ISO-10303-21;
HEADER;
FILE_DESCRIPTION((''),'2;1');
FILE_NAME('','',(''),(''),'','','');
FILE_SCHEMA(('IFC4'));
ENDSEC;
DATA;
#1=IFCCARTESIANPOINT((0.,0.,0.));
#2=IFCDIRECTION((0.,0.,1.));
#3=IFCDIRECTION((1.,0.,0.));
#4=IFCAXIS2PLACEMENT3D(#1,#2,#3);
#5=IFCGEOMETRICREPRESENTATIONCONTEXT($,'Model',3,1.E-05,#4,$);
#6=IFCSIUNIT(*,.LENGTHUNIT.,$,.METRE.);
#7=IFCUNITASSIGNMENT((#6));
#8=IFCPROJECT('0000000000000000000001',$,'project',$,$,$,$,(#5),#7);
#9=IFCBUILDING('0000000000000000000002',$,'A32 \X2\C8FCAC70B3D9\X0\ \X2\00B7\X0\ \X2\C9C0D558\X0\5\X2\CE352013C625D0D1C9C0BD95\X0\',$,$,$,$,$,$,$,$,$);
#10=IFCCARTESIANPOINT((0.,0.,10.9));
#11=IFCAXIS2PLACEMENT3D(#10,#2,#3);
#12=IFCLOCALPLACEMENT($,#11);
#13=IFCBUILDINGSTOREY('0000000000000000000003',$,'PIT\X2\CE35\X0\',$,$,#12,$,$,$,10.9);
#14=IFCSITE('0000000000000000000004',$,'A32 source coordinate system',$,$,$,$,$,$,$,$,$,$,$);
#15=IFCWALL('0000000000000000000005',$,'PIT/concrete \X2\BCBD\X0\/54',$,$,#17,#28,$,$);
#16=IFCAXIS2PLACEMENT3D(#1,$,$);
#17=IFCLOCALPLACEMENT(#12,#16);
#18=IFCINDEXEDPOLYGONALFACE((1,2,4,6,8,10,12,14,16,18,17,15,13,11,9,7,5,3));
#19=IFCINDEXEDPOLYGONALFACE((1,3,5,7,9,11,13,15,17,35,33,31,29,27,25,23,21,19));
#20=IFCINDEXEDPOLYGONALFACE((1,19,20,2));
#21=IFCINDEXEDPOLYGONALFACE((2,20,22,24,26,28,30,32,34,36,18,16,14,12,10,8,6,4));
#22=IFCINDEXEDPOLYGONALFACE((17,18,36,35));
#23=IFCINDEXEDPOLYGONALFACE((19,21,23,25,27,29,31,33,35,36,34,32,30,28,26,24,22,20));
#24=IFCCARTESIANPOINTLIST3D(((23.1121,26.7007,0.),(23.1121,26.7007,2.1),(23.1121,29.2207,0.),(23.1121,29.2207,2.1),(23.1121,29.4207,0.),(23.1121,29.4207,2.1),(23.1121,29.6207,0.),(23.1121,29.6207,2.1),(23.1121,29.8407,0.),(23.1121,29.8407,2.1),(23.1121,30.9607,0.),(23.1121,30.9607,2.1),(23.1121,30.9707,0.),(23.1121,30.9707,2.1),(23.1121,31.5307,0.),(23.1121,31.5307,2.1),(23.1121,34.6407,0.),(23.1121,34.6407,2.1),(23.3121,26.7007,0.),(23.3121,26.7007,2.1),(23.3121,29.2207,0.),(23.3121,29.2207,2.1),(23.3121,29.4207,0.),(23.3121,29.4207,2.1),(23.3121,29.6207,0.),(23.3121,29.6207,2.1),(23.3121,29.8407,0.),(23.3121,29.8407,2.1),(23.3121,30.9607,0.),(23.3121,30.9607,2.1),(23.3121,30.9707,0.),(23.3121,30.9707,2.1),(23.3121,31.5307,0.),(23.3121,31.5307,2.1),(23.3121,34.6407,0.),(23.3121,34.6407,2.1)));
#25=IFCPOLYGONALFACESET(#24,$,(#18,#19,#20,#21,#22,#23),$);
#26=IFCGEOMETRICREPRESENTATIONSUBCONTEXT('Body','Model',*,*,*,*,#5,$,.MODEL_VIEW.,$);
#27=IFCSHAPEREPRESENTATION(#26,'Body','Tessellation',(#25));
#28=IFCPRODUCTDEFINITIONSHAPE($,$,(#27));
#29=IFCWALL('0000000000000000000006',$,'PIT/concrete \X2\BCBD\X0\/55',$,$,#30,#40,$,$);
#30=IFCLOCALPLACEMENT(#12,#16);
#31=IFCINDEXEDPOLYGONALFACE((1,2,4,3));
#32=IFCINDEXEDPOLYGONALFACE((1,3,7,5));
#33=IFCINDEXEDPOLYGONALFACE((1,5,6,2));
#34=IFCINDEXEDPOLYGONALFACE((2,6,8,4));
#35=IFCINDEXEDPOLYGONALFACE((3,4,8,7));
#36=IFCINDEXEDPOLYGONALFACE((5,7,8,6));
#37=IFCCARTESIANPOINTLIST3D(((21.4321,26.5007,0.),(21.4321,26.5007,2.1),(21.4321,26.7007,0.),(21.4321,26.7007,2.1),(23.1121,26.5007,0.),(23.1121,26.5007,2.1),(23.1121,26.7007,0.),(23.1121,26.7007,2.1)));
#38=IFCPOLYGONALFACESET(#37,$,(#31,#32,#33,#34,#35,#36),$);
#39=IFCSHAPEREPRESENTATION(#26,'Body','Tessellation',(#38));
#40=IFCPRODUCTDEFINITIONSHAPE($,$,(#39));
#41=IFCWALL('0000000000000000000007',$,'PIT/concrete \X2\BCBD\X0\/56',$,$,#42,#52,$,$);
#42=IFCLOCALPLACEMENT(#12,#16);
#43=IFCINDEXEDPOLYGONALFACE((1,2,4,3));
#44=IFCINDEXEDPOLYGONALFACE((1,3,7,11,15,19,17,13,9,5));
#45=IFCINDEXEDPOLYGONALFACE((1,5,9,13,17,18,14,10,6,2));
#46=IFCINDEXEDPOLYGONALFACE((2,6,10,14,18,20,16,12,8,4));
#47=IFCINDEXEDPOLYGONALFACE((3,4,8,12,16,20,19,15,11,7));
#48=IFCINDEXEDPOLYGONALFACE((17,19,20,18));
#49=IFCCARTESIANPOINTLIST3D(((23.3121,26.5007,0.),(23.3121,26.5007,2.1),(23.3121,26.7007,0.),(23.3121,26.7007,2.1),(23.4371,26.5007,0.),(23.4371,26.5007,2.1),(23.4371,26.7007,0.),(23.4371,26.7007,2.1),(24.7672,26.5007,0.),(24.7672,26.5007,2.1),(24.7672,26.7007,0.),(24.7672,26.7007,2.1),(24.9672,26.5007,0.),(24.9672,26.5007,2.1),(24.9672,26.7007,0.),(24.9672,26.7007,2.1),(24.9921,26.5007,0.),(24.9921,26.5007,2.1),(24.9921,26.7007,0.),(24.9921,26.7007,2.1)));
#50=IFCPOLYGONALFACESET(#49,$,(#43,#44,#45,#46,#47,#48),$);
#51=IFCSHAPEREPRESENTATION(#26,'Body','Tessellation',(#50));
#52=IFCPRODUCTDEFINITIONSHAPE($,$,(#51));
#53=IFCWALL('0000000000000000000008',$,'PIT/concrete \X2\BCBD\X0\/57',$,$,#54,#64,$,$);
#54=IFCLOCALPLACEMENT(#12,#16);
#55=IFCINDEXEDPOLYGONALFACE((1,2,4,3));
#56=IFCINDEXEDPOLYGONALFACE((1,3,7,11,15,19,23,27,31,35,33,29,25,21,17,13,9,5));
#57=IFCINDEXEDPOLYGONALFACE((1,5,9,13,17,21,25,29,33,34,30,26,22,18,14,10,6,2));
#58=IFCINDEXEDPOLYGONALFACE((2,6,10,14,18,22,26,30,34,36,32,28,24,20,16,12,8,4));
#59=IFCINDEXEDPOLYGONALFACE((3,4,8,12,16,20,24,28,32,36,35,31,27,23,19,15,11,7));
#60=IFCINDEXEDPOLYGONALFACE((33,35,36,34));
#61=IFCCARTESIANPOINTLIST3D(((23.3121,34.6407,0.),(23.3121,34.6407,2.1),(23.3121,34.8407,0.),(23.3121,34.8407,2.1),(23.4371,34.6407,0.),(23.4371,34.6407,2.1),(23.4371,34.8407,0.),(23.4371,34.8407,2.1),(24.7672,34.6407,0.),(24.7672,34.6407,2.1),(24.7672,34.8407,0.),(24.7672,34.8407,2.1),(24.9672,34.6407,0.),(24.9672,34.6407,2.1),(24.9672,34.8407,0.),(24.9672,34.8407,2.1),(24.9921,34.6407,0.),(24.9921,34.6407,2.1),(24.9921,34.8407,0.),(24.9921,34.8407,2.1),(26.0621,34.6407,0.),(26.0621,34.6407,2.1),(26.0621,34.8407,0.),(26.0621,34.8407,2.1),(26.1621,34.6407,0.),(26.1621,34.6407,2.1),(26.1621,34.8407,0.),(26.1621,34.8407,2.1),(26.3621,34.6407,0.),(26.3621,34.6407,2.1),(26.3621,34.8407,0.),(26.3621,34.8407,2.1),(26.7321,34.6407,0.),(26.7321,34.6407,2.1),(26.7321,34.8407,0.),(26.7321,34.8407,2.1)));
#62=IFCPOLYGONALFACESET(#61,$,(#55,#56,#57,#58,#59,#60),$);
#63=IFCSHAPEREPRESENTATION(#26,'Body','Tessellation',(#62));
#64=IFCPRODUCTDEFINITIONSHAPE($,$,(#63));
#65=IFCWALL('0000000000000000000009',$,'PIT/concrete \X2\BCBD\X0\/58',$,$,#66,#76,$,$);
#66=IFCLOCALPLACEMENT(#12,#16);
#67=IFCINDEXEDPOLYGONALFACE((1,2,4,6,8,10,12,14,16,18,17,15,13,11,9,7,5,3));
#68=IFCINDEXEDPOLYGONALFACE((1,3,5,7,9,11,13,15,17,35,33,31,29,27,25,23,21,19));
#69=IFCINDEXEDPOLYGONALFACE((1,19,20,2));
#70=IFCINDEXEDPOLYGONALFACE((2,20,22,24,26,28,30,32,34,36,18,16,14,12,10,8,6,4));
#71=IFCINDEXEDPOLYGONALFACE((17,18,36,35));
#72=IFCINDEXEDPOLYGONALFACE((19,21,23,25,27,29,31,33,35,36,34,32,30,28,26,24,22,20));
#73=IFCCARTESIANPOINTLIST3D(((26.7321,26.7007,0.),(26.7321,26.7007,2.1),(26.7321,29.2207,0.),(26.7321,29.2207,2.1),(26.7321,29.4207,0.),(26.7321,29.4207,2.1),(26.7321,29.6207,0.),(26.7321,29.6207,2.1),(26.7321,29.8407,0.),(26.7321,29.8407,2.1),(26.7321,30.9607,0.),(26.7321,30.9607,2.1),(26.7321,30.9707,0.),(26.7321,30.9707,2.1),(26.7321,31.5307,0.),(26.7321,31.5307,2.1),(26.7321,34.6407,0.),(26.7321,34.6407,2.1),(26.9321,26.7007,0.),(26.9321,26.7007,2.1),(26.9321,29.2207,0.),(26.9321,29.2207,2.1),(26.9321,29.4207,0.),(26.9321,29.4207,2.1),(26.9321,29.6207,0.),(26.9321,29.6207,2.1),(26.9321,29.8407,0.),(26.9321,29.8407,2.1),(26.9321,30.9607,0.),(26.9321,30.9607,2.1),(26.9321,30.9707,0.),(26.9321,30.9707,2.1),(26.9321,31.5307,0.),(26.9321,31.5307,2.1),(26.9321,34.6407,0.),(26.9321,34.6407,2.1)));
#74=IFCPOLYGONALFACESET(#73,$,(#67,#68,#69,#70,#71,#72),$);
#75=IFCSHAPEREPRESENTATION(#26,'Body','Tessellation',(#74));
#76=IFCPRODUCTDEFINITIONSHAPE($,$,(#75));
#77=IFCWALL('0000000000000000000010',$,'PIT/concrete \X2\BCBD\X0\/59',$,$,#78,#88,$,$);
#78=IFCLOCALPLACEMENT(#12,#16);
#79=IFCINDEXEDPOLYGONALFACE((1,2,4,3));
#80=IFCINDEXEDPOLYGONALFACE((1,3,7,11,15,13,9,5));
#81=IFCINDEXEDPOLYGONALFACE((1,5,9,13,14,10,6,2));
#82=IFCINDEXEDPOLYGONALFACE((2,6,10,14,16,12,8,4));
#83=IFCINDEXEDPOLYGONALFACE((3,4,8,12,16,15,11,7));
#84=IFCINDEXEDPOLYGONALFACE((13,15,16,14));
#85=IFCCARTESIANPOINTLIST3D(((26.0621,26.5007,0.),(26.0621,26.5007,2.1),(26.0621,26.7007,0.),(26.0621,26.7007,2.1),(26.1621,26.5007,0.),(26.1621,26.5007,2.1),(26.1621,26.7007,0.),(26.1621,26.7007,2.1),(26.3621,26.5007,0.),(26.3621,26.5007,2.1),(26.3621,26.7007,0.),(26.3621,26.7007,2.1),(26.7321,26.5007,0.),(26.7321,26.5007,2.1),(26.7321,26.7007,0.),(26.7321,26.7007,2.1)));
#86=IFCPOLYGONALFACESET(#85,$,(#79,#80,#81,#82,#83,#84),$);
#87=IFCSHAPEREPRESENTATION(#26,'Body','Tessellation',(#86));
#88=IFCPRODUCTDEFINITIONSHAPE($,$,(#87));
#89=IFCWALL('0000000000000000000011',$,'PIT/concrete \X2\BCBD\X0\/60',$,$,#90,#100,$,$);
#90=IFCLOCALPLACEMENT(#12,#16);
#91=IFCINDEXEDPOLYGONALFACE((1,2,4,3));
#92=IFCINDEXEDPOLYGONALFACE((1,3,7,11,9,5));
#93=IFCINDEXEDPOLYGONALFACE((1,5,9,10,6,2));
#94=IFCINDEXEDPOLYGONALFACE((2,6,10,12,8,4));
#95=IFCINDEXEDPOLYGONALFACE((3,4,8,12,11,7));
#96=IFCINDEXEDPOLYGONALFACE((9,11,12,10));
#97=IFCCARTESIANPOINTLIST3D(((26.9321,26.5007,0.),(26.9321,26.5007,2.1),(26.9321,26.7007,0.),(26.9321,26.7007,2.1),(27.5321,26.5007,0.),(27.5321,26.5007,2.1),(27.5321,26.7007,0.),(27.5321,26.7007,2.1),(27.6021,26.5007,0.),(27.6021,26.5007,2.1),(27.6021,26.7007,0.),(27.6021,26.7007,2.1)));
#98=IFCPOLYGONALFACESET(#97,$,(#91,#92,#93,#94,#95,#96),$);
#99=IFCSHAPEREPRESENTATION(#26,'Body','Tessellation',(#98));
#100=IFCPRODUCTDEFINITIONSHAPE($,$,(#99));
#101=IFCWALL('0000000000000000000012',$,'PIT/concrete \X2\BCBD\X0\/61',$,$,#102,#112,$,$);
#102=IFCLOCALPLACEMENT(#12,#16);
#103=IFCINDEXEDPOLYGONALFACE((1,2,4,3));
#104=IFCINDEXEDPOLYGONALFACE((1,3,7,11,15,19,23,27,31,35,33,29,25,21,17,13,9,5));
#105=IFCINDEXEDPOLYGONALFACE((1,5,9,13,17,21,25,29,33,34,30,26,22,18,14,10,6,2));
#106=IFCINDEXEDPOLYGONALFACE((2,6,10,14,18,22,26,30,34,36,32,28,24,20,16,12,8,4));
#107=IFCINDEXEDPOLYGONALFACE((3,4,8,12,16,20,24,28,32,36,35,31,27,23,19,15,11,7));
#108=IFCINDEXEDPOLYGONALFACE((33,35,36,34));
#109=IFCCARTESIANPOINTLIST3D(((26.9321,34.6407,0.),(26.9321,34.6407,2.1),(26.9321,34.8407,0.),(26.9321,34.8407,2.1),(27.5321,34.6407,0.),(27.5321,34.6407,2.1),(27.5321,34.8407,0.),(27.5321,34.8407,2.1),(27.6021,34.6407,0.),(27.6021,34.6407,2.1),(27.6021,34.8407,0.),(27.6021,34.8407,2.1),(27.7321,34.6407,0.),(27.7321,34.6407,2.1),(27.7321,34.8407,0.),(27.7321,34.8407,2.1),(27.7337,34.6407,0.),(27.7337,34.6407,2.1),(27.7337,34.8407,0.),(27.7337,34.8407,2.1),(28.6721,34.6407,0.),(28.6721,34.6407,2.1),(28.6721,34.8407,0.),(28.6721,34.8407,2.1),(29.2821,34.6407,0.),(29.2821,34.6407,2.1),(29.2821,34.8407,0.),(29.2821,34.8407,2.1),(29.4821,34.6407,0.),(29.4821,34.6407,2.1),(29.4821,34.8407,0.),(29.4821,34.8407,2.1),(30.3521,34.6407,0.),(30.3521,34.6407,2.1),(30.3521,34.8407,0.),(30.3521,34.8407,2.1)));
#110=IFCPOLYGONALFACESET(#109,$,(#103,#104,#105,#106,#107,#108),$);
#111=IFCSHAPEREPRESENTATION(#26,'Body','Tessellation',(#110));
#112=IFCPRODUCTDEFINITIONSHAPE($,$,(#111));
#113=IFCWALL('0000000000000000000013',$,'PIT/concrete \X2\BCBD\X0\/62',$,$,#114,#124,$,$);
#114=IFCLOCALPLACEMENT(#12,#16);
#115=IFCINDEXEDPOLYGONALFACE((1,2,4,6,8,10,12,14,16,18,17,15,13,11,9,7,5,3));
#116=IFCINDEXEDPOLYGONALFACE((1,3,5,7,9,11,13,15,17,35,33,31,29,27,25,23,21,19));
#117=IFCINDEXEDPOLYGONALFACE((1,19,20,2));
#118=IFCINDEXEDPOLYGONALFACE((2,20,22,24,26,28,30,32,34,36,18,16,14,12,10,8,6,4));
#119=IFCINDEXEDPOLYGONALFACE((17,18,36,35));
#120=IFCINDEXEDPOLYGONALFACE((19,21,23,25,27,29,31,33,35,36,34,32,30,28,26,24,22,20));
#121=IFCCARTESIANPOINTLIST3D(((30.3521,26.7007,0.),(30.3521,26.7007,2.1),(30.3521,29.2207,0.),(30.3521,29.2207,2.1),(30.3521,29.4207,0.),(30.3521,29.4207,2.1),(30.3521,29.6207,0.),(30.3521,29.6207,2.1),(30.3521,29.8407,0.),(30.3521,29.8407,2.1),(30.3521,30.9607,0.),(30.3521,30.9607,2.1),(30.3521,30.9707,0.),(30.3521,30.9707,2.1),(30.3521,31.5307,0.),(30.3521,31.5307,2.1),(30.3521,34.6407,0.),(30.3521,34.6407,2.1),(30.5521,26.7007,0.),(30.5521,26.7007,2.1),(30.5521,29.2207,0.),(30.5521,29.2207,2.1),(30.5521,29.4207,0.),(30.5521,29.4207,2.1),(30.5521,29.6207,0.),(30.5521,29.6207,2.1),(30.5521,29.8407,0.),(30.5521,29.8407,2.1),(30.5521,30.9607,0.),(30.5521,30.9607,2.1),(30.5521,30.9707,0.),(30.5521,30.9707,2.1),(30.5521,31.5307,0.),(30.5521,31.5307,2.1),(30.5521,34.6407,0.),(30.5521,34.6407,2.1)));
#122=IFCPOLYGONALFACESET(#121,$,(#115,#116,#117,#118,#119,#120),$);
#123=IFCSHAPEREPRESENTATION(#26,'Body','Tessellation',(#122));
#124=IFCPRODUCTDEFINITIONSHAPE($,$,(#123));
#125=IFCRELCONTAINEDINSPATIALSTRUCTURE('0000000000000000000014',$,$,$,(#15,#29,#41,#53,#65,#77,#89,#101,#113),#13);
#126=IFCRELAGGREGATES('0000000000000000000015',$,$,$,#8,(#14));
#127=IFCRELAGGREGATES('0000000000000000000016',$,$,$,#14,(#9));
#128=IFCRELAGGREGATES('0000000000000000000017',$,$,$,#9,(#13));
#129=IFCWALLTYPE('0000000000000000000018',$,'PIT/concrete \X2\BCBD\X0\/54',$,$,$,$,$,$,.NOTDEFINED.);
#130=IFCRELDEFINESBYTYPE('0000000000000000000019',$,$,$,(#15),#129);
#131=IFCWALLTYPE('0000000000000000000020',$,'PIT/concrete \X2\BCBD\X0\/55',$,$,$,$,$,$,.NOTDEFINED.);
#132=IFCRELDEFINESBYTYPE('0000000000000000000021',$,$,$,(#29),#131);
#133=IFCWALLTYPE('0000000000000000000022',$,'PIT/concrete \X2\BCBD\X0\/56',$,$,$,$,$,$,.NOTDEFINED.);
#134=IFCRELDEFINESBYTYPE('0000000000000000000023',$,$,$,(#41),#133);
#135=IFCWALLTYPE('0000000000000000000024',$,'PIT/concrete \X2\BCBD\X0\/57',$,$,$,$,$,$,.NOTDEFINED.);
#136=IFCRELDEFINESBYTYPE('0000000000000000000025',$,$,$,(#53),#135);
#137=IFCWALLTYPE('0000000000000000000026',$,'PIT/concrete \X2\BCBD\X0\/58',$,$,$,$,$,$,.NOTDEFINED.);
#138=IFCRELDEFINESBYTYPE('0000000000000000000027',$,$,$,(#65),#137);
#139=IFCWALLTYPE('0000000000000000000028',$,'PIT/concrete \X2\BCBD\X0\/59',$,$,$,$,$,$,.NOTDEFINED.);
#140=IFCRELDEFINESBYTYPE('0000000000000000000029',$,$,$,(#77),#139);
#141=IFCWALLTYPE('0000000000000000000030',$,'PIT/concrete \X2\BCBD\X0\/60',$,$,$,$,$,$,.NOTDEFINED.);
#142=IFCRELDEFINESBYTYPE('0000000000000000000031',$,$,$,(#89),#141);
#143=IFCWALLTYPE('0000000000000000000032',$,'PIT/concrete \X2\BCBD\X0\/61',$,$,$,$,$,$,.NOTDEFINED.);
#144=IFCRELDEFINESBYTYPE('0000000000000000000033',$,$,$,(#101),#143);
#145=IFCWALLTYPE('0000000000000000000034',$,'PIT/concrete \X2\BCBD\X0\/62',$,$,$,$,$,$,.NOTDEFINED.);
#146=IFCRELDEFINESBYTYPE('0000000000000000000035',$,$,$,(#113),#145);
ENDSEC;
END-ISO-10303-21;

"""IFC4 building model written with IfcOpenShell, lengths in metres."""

from ifc_helpers import new_model, si_unit, frame, origin, origin_with_axes, place, context, subcontext, project, spatial, polyline, outline, extrude, source, transform, mapped, type_object, type_shapes, element, save


model = new_model("IFC4")

# Units and contexts
model_context = context("Model", 3, precision=1e-05, world=origin_with_axes())
body_context = subcontext(model_context, "Body", "Model", "MODEL_VIEW")
ifc_project = project(units=[si_unit("LENGTHUNIT", "METRE")], contexts=[model_context])

# Site, building, storey
site = spatial("IfcSite", under=ifc_project, Name="A32 source coordinate system")
building = spatial("IfcBuilding", under=site, Name="A32 주거동 · 지하5층–옥탑지붕")
storey_placement = place(None, frame((0.0, 0.0, 10.9), z_axis=(0.0, 0.0, 1.0), x_axis=(1.0, 0.0, 0.0)))
storey = spatial("IfcBuildingStorey", under=building, at=storey_placement, Name="PIT층", Elevation=10.9)

# Walls
wall_type_1 = type_object("IfcWallType", Name="PIT/concrete 벽/54", PredefinedType="NOTDEFINED")
shared_shape_1 = source(origin(), body_context, "Body", "SweptSolid", [
    extrude(outline(polyline([(23.3121, 30.9707), (23.3121, 30.9607), (23.3121, 29.8407), (23.3121, 29.6207), (23.3121, 29.4207), (23.3121, 29.2207), (23.3121, 26.7007), (23.1121, 26.7007), (23.1121, 29.2207), (23.1121, 29.4207), (23.1121, 29.6207), (23.1121, 29.8407), (23.1121, 30.9607), (23.1121, 30.9707), (23.1121, 31.5307), (23.1121, 34.6407), (23.3121, 34.6407), (23.3121, 31.5307), (23.3121, 30.9707)])), origin(), (0.0, 0.0, 1.0), 2.1),
])
type_shapes(wall_type_1, [shared_shape_1])
wall_1_placement = place(storey_placement, origin_with_axes())
element("IfcWall", 1, at=wall_1_placement, inside=storey, type_object=wall_type_1, Name="PIT/concrete 벽/54", context=body_context, shape_type="MappedRepresentation", body=[
    mapped(shared_shape_1, transform((0.0, 0.0, 0.0), scale=1.0)),
])
wall_type_2 = type_object("IfcWallType", Name="PIT/concrete 벽/55", PredefinedType="NOTDEFINED")
shared_shape_2 = source(origin(), body_context, "Body", "SweptSolid", [
    extrude(outline(polyline([(21.4321, 26.7007), (23.1121, 26.7007), (23.1121, 26.5007), (21.4321, 26.5007), (21.4321, 26.7007)])), origin(), (0.0, 0.0, 1.0), 2.1),
])
type_shapes(wall_type_2, [shared_shape_2])
wall_2_placement = place(storey_placement, origin_with_axes())
element("IfcWall", 2, at=wall_2_placement, inside=storey, type_object=wall_type_2, Name="PIT/concrete 벽/55", context=body_context, shape_type="MappedRepresentation", body=[
    mapped(shared_shape_2, transform((0.0, 0.0, 0.0), scale=1.0)),
])
wall_type_3 = type_object("IfcWallType", Name="PIT/concrete 벽/56", PredefinedType="NOTDEFINED")
shared_shape_3 = source(origin(), body_context, "Body", "SweptSolid", [
    extrude(outline(polyline([(24.9672, 26.7007), (24.9921, 26.7007), (24.9921, 26.5007), (24.9672, 26.5007), (24.7672, 26.5007), (23.4371, 26.5007), (23.3121, 26.5007), (23.3121, 26.7007), (23.4371, 26.7007), (24.7672, 26.7007), (24.9672, 26.7007)])), origin(), (0.0, 0.0, 1.0), 2.1),
])
type_shapes(wall_type_3, [shared_shape_3])
wall_3_placement = place(storey_placement, origin_with_axes())
element("IfcWall", 3, at=wall_3_placement, inside=storey, type_object=wall_type_3, Name="PIT/concrete 벽/56", context=body_context, shape_type="MappedRepresentation", body=[
    mapped(shared_shape_3, transform((0.0, 0.0, 0.0), scale=1.0)),
])
wall_type_4 = type_object("IfcWallType", Name="PIT/concrete 벽/57", PredefinedType="NOTDEFINED")
shared_shape_4 = source(origin(), body_context, "Body", "SweptSolid", [
    extrude(outline(polyline([(24.7672, 34.8407), (24.9672, 34.8407), (24.9921, 34.8407), (26.0621, 34.8407), (26.1621, 34.8407), (26.3621, 34.8407), (26.7321, 34.8407), (26.7321, 34.6407), (26.3621, 34.6407), (26.1621, 34.6407), (26.0621, 34.6407), (24.9921, 34.6407), (24.9672, 34.6407), (24.7672, 34.6407), (23.4371, 34.6407), (23.3121, 34.6407), (23.3121, 34.8407), (23.4371, 34.8407), (24.7672, 34.8407)])), origin(), (0.0, 0.0, 1.0), 2.1),
])
type_shapes(wall_type_4, [shared_shape_4])
wall_4_placement = place(storey_placement, origin_with_axes())
element("IfcWall", 4, at=wall_4_placement, inside=storey, type_object=wall_type_4, Name="PIT/concrete 벽/57", context=body_context, shape_type="MappedRepresentation", body=[
    mapped(shared_shape_4, transform((0.0, 0.0, 0.0), scale=1.0)),
])
wall_type_5 = type_object("IfcWallType", Name="PIT/concrete 벽/58", PredefinedType="NOTDEFINED")
shared_shape_5 = source(origin(), body_context, "Body", "SweptSolid", [
    extrude(outline(polyline([(26.9321, 30.9707), (26.9321, 30.9607), (26.9321, 29.8407), (26.9321, 29.6207), (26.9321, 29.4207), (26.9321, 29.2207), (26.9321, 26.7007), (26.7321, 26.7007), (26.7321, 29.2207), (26.7321, 29.4207), (26.7321, 29.6207), (26.7321, 29.8407), (26.7321, 30.9607), (26.7321, 30.9707), (26.7321, 31.5307), (26.7321, 34.6407), (26.9321, 34.6407), (26.9321, 31.5307), (26.9321, 30.9707)])), origin(), (0.0, 0.0, 1.0), 2.1),
])
type_shapes(wall_type_5, [shared_shape_5])
wall_5_placement = place(storey_placement, origin_with_axes())
element("IfcWall", 5, at=wall_5_placement, inside=storey, type_object=wall_type_5, Name="PIT/concrete 벽/58", context=body_context, shape_type="MappedRepresentation", body=[
    mapped(shared_shape_5, transform((0.0, 0.0, 0.0), scale=1.0)),
])
wall_type_6 = type_object("IfcWallType", Name="PIT/concrete 벽/59", PredefinedType="NOTDEFINED")
shared_shape_6 = source(origin(), body_context, "Body", "SweptSolid", [
    extrude(outline(polyline([(26.1621, 26.5007), (26.0621, 26.5007), (26.0621, 26.7007), (26.1621, 26.7007), (26.3621, 26.7007), (26.7321, 26.7007), (26.7321, 26.5007), (26.3621, 26.5007), (26.1621, 26.5007)])), origin(), (0.0, 0.0, 1.0), 2.1),
])
type_shapes(wall_type_6, [shared_shape_6])
wall_6_placement = place(storey_placement, origin_with_axes())
element("IfcWall", 6, at=wall_6_placement, inside=storey, type_object=wall_type_6, Name="PIT/concrete 벽/59", context=body_context, shape_type="MappedRepresentation", body=[
    mapped(shared_shape_6, transform((0.0, 0.0, 0.0), scale=1.0)),
])
wall_type_7 = type_object("IfcWallType", Name="PIT/concrete 벽/60", PredefinedType="NOTDEFINED")
shared_shape_7 = source(origin(), body_context, "Body", "SweptSolid", [
    extrude(outline(polyline([(27.6021, 26.5007), (27.5321, 26.5007), (26.9321, 26.5007), (26.9321, 26.7007), (27.5321, 26.7007), (27.6021, 26.7007), (27.6021, 26.5007)])), origin(), (0.0, 0.0, 1.0), 2.1),
])
type_shapes(wall_type_7, [shared_shape_7])
wall_7_placement = place(storey_placement, origin_with_axes())
element("IfcWall", 7, at=wall_7_placement, inside=storey, type_object=wall_type_7, Name="PIT/concrete 벽/60", context=body_context, shape_type="MappedRepresentation", body=[
    mapped(shared_shape_7, transform((0.0, 0.0, 0.0), scale=1.0)),
])
wall_type_8 = type_object("IfcWallType", Name="PIT/concrete 벽/61", PredefinedType="NOTDEFINED")
shared_shape_8 = source(origin(), body_context, "Body", "SweptSolid", [
    extrude(outline(polyline([(27.6021, 34.8407), (27.7321, 34.8407), (27.7337, 34.8407), (28.6721, 34.8407), (29.2821, 34.8407), (29.4821, 34.8407), (30.3521, 34.8407), (30.3521, 34.6407), (29.4821, 34.6407), (29.2821, 34.6407), (28.6721, 34.6407), (27.7337, 34.6407), (27.7321, 34.6407), (27.6021, 34.6407), (27.5321, 34.6407), (26.9321, 34.6407), (26.9321, 34.8407), (27.5321, 34.8407), (27.6021, 34.8407)])), origin(), (0.0, 0.0, 1.0), 2.1),
])
type_shapes(wall_type_8, [shared_shape_8])
wall_8_placement = place(storey_placement, origin_with_axes())
element("IfcWall", 8, at=wall_8_placement, inside=storey, type_object=wall_type_8, Name="PIT/concrete 벽/61", context=body_context, shape_type="MappedRepresentation", body=[
    mapped(shared_shape_8, transform((0.0, 0.0, 0.0), scale=1.0)),
])
wall_type_9 = type_object("IfcWallType", Name="PIT/concrete 벽/62", PredefinedType="NOTDEFINED")
shared_shape_9 = source(origin(), body_context, "Body", "SweptSolid", [
    extrude(outline(polyline([(30.5521, 30.9707), (30.5521, 30.9607), (30.5521, 29.8407), (30.5521, 29.6207), (30.5521, 29.4207), (30.5521, 29.2207), (30.5521, 26.7007), (30.3521, 26.7007), (30.3521, 29.2207), (30.3521, 29.4207), (30.3521, 29.6207), (30.3521, 29.8407), (30.3521, 30.9607), (30.3521, 30.9707), (30.3521, 31.5307), (30.3521, 34.6407), (30.5521, 34.6407), (30.5521, 31.5307), (30.5521, 30.9707)])), origin(), (0.0, 0.0, 1.0), 2.1),
])
type_shapes(wall_type_9, [shared_shape_9])
wall_9_placement = place(storey_placement, origin_with_axes())
element("IfcWall", 9, at=wall_9_placement, inside=storey, type_object=wall_type_9, Name="PIT/concrete 벽/62", context=body_context, shape_type="MappedRepresentation", body=[
    mapped(shared_shape_9, transform((0.0, 0.0, 0.0), scale=1.0)),
])

save(model, "model.ifc")
